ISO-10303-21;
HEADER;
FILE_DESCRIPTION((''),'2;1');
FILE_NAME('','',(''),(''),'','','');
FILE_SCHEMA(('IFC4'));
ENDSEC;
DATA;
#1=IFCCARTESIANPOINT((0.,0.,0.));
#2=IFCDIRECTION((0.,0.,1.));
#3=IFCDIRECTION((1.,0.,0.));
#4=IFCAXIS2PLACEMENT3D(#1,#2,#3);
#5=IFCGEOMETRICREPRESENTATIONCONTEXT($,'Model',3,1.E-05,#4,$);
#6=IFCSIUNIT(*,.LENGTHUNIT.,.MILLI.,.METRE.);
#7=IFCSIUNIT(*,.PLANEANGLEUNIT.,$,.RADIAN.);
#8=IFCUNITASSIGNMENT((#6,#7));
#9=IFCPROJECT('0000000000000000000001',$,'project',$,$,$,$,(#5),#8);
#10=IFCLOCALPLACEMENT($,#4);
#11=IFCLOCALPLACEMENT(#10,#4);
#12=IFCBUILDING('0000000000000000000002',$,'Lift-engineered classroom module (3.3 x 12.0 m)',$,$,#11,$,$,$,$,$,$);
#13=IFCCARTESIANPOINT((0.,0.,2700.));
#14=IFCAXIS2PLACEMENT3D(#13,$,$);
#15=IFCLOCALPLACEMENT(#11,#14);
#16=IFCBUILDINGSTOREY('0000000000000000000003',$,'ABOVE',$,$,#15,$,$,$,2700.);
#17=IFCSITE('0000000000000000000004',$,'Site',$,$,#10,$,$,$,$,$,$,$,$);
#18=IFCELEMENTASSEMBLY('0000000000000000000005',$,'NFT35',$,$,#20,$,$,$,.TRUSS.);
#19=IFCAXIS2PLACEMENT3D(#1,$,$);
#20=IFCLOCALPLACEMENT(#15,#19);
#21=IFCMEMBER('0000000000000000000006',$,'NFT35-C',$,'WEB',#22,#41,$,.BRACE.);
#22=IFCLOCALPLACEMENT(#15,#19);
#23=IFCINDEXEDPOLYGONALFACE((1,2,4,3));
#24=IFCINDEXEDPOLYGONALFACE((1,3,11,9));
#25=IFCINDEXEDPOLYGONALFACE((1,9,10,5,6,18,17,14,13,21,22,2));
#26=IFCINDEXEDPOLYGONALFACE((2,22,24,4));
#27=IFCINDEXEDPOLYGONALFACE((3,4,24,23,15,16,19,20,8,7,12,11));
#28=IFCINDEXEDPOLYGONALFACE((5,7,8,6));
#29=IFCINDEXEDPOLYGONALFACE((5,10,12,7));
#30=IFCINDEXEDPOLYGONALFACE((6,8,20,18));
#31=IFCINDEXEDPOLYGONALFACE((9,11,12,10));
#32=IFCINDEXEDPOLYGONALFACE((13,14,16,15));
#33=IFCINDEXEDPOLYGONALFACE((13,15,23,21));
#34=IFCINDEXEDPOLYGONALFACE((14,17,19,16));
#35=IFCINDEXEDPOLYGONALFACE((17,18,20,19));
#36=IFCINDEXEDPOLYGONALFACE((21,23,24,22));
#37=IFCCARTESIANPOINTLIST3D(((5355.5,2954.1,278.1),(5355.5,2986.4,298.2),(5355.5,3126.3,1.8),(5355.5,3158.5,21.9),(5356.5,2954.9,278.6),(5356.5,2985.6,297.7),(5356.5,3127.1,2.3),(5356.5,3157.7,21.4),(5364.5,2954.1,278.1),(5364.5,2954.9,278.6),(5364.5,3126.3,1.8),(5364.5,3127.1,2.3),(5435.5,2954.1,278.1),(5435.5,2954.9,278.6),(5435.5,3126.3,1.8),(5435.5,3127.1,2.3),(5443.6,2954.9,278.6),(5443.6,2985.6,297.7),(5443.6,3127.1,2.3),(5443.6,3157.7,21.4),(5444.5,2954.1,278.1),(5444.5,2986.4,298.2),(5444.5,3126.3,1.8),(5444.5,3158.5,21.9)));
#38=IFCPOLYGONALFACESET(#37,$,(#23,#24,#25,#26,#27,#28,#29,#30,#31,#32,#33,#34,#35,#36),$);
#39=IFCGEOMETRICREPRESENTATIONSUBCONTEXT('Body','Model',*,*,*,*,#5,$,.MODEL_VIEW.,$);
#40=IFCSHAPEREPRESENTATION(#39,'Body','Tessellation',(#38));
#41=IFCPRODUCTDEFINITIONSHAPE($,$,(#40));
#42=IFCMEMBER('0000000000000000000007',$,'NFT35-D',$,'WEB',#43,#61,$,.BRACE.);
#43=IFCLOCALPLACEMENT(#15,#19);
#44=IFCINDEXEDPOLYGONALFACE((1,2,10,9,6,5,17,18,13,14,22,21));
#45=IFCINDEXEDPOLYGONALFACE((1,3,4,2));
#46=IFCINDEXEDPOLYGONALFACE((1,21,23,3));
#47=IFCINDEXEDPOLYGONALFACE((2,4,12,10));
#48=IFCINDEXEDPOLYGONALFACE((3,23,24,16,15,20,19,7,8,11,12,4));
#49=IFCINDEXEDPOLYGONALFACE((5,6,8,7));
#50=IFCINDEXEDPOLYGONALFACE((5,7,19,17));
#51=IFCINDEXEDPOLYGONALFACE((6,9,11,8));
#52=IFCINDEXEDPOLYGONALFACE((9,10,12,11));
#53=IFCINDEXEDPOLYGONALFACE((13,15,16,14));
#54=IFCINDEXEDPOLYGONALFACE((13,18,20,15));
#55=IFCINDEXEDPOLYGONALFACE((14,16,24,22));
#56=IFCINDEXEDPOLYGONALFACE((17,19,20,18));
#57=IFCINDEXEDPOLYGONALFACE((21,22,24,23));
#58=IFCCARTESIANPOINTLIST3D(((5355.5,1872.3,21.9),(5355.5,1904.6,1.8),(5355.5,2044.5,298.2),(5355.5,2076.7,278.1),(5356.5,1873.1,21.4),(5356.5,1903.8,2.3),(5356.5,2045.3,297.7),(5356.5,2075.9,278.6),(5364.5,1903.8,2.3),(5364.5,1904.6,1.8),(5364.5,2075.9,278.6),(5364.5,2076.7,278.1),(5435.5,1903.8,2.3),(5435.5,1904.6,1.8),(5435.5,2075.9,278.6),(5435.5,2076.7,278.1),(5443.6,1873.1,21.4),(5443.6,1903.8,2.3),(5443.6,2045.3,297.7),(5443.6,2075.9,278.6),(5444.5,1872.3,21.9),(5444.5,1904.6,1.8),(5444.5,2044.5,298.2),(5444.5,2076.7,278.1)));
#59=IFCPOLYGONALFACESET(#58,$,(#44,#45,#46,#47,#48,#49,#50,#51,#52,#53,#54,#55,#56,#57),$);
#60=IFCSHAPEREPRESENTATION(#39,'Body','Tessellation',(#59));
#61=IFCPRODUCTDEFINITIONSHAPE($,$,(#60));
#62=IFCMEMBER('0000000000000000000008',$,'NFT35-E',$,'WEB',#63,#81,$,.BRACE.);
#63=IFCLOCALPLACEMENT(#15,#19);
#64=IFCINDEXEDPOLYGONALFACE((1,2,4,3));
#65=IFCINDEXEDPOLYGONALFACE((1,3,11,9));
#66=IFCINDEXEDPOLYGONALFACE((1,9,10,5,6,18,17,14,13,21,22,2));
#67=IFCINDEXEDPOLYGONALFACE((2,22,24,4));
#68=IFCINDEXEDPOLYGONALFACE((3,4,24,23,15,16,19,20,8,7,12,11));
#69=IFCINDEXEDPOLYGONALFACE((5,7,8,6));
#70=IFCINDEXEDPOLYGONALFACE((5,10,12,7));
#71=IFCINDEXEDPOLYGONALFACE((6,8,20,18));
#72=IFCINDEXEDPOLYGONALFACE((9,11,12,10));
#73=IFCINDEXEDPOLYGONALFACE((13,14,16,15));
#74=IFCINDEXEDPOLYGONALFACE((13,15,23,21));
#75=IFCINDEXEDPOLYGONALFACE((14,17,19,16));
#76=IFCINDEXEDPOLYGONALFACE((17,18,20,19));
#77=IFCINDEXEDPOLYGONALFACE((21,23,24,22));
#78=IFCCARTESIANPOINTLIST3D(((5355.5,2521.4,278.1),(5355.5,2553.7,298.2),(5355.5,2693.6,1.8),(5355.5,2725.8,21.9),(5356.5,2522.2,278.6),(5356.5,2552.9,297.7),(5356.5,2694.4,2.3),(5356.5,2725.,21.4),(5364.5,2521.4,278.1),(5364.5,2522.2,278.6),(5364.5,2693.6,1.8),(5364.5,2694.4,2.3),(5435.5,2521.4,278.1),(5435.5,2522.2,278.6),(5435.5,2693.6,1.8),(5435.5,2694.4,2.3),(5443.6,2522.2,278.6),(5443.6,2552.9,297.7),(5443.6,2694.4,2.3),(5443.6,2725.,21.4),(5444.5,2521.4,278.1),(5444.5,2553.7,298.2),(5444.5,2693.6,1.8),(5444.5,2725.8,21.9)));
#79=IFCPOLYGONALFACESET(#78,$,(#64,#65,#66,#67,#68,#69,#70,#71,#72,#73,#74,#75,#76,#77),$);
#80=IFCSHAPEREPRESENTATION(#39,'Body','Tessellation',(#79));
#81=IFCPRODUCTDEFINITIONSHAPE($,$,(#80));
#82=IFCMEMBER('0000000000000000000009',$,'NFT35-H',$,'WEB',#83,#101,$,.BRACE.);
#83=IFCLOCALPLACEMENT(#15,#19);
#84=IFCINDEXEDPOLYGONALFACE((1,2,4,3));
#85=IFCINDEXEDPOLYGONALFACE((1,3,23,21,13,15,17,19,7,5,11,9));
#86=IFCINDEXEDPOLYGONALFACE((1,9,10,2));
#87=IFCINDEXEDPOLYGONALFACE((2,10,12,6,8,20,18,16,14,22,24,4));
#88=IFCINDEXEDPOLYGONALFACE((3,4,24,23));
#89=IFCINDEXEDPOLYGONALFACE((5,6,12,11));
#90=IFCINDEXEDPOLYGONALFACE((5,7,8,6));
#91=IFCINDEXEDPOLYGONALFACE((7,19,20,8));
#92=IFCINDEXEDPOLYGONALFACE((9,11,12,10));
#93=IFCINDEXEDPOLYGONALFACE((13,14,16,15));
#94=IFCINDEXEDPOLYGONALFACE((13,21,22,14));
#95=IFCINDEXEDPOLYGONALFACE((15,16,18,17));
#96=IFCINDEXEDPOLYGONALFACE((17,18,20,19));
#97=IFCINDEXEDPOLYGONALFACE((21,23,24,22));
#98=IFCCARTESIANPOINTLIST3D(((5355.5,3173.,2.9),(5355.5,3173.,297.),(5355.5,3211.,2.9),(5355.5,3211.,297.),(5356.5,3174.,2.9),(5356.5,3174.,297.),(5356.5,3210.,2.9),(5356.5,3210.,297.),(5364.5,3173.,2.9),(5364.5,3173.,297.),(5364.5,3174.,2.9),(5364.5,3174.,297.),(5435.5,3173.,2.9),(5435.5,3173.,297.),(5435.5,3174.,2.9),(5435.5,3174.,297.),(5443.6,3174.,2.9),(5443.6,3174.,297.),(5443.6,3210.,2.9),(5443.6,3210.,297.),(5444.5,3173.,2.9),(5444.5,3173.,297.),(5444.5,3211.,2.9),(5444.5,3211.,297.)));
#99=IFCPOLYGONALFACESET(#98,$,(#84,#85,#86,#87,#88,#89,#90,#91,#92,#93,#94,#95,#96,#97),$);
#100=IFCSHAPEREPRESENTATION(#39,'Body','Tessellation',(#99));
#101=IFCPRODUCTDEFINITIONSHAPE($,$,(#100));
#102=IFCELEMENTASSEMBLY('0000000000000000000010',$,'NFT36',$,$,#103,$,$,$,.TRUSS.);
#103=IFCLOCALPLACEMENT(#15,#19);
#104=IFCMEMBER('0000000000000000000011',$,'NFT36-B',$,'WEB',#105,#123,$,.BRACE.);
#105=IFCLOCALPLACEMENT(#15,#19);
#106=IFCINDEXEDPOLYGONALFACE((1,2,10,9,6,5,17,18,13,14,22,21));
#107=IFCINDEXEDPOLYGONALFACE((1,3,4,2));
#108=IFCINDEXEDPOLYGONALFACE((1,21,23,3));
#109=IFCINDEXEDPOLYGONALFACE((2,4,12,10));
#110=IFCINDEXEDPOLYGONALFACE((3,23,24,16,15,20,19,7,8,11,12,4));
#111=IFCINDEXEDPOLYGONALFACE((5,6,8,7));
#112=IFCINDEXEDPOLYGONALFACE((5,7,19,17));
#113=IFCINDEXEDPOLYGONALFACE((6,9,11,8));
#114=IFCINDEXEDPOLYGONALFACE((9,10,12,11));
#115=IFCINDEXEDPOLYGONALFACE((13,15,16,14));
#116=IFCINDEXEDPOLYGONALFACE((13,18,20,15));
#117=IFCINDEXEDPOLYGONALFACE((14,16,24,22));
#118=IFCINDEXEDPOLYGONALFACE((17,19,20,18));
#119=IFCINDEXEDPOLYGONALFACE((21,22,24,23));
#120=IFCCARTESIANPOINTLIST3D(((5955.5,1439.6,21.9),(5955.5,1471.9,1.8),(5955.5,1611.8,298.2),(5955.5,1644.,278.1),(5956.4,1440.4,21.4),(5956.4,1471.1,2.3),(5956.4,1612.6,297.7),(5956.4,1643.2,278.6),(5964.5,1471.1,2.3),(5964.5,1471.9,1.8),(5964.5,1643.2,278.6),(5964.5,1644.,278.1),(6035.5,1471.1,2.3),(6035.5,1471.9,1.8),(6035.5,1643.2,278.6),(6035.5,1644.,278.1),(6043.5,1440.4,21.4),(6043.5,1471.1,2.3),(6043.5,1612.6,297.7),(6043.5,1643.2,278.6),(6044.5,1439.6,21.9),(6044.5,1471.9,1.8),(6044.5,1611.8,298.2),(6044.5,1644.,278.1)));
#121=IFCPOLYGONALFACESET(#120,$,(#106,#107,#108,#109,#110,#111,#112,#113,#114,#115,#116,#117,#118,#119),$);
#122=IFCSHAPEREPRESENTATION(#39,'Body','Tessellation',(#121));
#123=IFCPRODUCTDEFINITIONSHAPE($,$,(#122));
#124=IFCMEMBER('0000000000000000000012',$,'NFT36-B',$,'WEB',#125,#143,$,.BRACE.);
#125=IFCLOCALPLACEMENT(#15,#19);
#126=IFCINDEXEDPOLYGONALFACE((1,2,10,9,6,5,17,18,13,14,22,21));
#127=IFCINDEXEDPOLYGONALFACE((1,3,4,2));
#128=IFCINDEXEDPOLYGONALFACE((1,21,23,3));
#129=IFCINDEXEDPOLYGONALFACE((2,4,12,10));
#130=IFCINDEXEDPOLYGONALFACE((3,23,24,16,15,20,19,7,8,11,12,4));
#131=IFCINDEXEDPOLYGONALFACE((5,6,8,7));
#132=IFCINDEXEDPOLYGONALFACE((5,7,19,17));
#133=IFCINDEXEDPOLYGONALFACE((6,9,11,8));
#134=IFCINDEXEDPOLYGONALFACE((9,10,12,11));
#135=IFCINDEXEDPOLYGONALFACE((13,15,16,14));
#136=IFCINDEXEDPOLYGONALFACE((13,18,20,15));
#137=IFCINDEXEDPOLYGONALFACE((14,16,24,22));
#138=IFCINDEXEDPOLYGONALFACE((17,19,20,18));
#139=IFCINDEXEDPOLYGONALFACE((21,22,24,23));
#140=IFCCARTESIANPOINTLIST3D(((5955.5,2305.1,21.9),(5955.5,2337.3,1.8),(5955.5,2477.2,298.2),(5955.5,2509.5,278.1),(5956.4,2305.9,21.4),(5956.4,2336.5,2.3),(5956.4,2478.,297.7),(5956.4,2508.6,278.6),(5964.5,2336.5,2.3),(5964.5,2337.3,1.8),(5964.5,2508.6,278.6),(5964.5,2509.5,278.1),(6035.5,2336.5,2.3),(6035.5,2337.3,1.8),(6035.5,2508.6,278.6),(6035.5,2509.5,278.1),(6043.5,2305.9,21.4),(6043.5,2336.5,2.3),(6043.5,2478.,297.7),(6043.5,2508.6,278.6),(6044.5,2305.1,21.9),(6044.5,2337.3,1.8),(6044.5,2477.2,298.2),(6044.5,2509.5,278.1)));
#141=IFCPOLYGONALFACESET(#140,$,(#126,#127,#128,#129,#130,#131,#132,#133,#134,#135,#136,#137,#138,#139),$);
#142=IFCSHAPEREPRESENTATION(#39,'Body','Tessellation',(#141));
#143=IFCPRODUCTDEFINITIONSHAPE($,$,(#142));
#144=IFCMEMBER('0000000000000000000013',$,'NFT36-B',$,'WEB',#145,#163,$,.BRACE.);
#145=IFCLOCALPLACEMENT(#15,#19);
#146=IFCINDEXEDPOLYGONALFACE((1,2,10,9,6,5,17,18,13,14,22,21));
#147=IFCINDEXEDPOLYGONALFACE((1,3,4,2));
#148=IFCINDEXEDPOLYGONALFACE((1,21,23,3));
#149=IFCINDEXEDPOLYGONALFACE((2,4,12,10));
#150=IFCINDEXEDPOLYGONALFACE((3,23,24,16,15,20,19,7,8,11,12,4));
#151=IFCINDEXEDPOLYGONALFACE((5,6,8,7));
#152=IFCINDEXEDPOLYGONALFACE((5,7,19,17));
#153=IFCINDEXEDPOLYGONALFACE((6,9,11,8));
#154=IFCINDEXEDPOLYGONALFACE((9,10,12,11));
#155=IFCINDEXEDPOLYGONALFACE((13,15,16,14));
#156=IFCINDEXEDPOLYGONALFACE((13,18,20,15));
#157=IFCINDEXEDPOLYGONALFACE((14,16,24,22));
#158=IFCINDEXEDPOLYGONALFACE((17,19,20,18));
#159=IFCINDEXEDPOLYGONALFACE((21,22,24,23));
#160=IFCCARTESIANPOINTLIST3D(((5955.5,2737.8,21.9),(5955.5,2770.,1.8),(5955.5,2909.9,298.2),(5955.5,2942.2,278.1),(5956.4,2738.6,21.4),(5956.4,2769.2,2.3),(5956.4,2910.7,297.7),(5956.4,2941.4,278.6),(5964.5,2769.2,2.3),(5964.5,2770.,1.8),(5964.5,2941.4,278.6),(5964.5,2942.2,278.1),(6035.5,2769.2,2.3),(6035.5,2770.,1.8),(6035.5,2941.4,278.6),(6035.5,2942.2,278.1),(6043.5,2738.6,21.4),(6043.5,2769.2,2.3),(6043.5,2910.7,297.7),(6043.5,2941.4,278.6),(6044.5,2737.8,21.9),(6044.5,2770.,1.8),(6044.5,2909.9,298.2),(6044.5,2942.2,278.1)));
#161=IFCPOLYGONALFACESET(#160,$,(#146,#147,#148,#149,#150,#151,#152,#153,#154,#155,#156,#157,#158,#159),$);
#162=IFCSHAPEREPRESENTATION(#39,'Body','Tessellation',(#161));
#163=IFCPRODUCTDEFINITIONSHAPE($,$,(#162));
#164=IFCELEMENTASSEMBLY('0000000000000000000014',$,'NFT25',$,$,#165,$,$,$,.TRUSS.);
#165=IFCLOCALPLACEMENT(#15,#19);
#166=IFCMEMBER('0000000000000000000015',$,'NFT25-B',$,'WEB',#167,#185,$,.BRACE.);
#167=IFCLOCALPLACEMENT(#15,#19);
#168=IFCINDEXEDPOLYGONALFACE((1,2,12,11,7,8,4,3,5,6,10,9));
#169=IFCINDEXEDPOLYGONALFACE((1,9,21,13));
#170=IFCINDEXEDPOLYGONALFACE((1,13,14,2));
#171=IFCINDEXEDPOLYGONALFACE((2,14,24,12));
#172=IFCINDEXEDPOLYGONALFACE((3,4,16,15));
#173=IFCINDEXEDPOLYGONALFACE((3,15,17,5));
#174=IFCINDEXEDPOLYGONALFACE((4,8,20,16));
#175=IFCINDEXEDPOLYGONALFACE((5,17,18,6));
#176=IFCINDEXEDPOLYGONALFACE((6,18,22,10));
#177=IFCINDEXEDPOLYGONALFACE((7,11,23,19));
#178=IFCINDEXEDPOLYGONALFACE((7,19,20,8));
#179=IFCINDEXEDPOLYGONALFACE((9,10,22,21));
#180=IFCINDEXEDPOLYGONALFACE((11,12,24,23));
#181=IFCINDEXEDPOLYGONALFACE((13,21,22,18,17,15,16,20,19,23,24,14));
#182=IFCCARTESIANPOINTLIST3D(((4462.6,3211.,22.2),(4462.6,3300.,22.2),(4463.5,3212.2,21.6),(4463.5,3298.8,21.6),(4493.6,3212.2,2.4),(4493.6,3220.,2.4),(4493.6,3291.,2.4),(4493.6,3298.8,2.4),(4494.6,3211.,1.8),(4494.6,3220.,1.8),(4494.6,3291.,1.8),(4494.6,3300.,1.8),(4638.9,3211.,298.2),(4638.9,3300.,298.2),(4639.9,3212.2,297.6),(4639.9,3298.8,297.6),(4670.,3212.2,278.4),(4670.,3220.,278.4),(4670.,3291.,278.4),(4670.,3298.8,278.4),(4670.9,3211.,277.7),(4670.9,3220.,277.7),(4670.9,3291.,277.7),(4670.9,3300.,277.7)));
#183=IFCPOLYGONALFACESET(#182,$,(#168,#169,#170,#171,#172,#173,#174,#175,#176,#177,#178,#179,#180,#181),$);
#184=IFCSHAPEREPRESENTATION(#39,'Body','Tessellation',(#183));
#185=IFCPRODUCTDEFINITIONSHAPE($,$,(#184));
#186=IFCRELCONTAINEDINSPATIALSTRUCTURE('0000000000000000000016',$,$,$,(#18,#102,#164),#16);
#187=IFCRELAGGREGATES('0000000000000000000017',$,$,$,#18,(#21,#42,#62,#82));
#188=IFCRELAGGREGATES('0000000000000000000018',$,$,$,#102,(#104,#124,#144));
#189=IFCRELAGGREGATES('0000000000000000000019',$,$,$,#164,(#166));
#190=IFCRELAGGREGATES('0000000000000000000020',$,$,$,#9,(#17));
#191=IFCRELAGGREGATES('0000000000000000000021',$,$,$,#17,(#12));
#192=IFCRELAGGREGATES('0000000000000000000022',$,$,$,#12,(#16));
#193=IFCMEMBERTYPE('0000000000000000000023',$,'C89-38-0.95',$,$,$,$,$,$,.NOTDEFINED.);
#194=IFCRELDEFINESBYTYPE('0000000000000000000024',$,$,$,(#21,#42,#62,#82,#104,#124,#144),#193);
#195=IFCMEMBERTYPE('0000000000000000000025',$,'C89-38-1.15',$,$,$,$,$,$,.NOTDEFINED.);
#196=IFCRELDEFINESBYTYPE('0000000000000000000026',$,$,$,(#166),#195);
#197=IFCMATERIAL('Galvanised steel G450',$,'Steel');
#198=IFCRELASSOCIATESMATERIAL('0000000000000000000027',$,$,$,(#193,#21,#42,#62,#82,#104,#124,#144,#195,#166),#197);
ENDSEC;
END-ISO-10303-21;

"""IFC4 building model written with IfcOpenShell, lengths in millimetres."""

from ifc_helpers import new_model, si_unit, frame, origin, origin_with_axes, origin_2d, place, context, subcontext, project, spatial, c_section, extrude, material, material_profile, profile_set, profile_usage, type_object, element, aggregate, save


model = new_model("IFC4")

# Units and contexts
model_context = context("Model", 3, precision=1e-05, world=origin_with_axes())
body_context = subcontext(model_context, "Body", "Model", "MODEL_VIEW")
ifc_project = project(units=[si_unit("LENGTHUNIT", "METRE", prefix="MILLI"), si_unit("PLANEANGLEUNIT", "RADIAN")], contexts=[model_context])

# Site, building, storey
site_placement = place(None, origin_with_axes())
site = spatial("IfcSite", under=ifc_project, at=site_placement, Name="Site")
building_placement = place(site_placement, origin_with_axes())
building = spatial("IfcBuilding", under=site, at=building_placement, Name="Lift-engineered classroom module (3.3 x 12.0 m)")
storey_placement = place(building_placement, frame((0.0, 0.0, 2700.0)))
storey = spatial("IfcBuildingStorey", under=building, at=storey_placement, Name="ABOVE", Elevation=2700.0)

# Element assemblies, members
ifc_material = material(Name="Galvanised steel G450", Category="Steel")
ifc_material_profile_1 = material_profile(ifc_material, c_section(Depth=89.0, Width=38.0, WallThickness=0.9, Girth=9.0, at=origin_2d()), Name="C89-38-0.95")
ifc_profile_set_1 = profile_set([ifc_material_profile_1], Name="C89-38-0.95")
ifc_profile_usage_1 = profile_usage(ifc_profile_set_1)
member_type_1 = type_object("IfcMemberType", Name="C89-38-0.95", PredefinedType="NOTDEFINED", material=ifc_profile_set_1)
assembly_1_placement = place(storey_placement, frame((5400.0, 89.0, 0.0)))
assembly_1 = element("IfcElementAssembly", 1, at=assembly_1_placement, inside=storey, Name="NFT35", PredefinedType="TRUSS")
member_1_placement = place(assembly_1_placement, frame((0.0, 3053.4, 11.8), z_axis=(0.0, -0.528797, 0.848748), x_axis=(0.0, -0.848748, -0.528797)))
member_1 = element("IfcMember", 2, at=member_1_placement, type_object=member_type_1, material=ifc_profile_usage_1, Name="NFT35-C", ObjectType="WEB", PredefinedType="BRACE", context=body_context, shape_type="SweptSolid", body=[
    extrude(c_section(Depth=89.0, Width=38.0, WallThickness=0.9, Girth=9.0, at=origin_2d()), origin(), (0.0, 0.0, 1.0), 325.6),
])
member_2_placement = place(assembly_1_placement, frame((0.0, 1799.5, 11.8), z_axis=(0.0, 0.528775, 0.848762), x_axis=(0.0, 0.848762, -0.528775)))
member_2 = element("IfcMember", 3, at=member_2_placement, type_object=member_type_1, material=ifc_profile_usage_1, Name="NFT35-D", ObjectType="WEB", PredefinedType="BRACE", context=body_context, shape_type="SweptSolid", body=[
    extrude(c_section(Depth=89.0, Width=38.0, WallThickness=0.9, Girth=9.0, at=origin_2d()), origin(), (0.0, 0.0, 1.0), 325.6),
])
member_3_placement = place(assembly_1_placement, frame((0.0, 2620.7, 11.8), z_axis=(0.0, -0.528775, 0.848762), x_axis=(0.0, -0.848762, -0.528775)))
member_3 = element("IfcMember", 4, at=member_3_placement, type_object=member_type_1, material=ifc_profile_usage_1, Name="NFT35-E", ObjectType="WEB", PredefinedType="BRACE", context=body_context, shape_type="SweptSolid", body=[
    extrude(c_section(Depth=89.0, Width=38.0, WallThickness=0.9, Girth=9.0, at=origin_2d()), origin(), (0.0, 0.0, 1.0), 325.6),
])
member_4_placement = place(assembly_1_placement, frame((0.0, 3103.0, 2.9), z_axis=(0.0, 0.0, 1.0), x_axis=(0.0, -1.0, 0.0)))
member_4 = element("IfcMember", 5, at=member_4_placement, type_object=member_type_1, material=ifc_profile_usage_1, Name="NFT35-H", ObjectType="WEB", PredefinedType="BRACE", context=body_context, shape_type="SweptSolid", body=[
    extrude(c_section(Depth=89.0, Width=38.0, WallThickness=0.9, Girth=9.0, at=origin_2d()), origin(), (0.0, 0.0, 1.0), 294.1),
])
aggregate(assembly_1, [member_1, member_2, member_3, member_4])
assembly_2_placement = place(storey_placement, frame((6000.0, 89.0, 0.0)))
assembly_2 = element("IfcElementAssembly", 6, at=assembly_2_placement, inside=storey, Name="NFT36", PredefinedType="TRUSS")
member_5_placement = place(assembly_2_placement, frame((0.0, 1366.7, 11.8), z_axis=(0.0, 0.528797, 0.848748), x_axis=(0.0, 0.848748, -0.528797)))
member_5 = element("IfcMember", 7, at=member_5_placement, type_object=member_type_1, material=ifc_profile_usage_1, Name="NFT36-B", ObjectType="WEB", PredefinedType="BRACE", context=body_context, shape_type="SweptSolid", body=[
    extrude(c_section(Depth=89.0, Width=38.0, WallThickness=0.9, Girth=9.0, at=origin_2d()), origin(), (0.0, 0.0, 1.0), 325.6),
])
member_6_placement = place(assembly_2_placement, frame((0.0, 2232.2, 11.8), z_axis=(0.0, 0.528797, 0.848748), x_axis=(0.0, 0.848748, -0.528797)))
member_6 = element("IfcMember", 8, at=member_6_placement, type_object=member_type_1, material=ifc_profile_usage_1, Name="NFT36-B", ObjectType="WEB", PredefinedType="BRACE", context=body_context, shape_type="SweptSolid", body=[
    extrude(c_section(Depth=89.0, Width=38.0, WallThickness=0.9, Girth=9.0, at=origin_2d()), origin(), (0.0, 0.0, 1.0), 325.6),
])
member_7_placement = place(assembly_2_placement, frame((0.0, 2664.9, 11.8), z_axis=(0.0, 0.528797, 0.848748), x_axis=(0.0, 0.848748, -0.528797)))
member_7 = element("IfcMember", 9, at=member_7_placement, type_object=member_type_1, material=ifc_profile_usage_1, Name="NFT36-B", ObjectType="WEB", PredefinedType="BRACE", context=body_context, shape_type="SweptSolid", body=[
    extrude(c_section(Depth=89.0, Width=38.0, WallThickness=0.9, Girth=9.0, at=origin_2d()), origin(), (0.0, 0.0, 1.0), 325.6),
])
aggregate(assembly_2, [member_5, member_6, member_7])
assembly_3_placement = place(storey_placement, frame((0.0, 3255.5, 0.0)))
assembly_3 = element("IfcElementAssembly", 10, at=assembly_3_placement, inside=storey, Name="NFT25", PredefinedType="TRUSS")
ifc_material_profile_2 = material_profile(ifc_material, c_section(Depth=89.0, Width=38.0, WallThickness=1.1, Girth=9.0, at=origin_2d()), Name="C89-38-1.15")
ifc_profile_set_2 = profile_set([ifc_material_profile_2], Name="C89-38-1.15")
ifc_profile_usage_2 = profile_usage(ifc_profile_set_2)
member_type_2 = type_object("IfcMemberType", Name="C89-38-1.15", PredefinedType="NOTDEFINED", material=ifc_profile_set_2)
member_8_placement = place(assembly_3_placement, frame((4478.6, 0.0, 12.0), z_axis=(0.538459, 0.0, 0.842652), x_axis=(0.842652, 0.0, -0.538459)))
member_8 = element("IfcMember", 11, at=member_8_placement, type_object=member_type_2, material=ifc_profile_usage_2, Name="NFT25-B", ObjectType="WEB", PredefinedType="BRACE", context=body_context, shape_type="SweptSolid", body=[
    extrude(c_section(Depth=89.0, Width=38.0, WallThickness=1.1, Girth=9.0, at=origin_2d()), origin(), (0.0, 0.0, 1.0), 327.5),
])
aggregate(assembly_3, [member_8])

save(model, "model.ifc")
